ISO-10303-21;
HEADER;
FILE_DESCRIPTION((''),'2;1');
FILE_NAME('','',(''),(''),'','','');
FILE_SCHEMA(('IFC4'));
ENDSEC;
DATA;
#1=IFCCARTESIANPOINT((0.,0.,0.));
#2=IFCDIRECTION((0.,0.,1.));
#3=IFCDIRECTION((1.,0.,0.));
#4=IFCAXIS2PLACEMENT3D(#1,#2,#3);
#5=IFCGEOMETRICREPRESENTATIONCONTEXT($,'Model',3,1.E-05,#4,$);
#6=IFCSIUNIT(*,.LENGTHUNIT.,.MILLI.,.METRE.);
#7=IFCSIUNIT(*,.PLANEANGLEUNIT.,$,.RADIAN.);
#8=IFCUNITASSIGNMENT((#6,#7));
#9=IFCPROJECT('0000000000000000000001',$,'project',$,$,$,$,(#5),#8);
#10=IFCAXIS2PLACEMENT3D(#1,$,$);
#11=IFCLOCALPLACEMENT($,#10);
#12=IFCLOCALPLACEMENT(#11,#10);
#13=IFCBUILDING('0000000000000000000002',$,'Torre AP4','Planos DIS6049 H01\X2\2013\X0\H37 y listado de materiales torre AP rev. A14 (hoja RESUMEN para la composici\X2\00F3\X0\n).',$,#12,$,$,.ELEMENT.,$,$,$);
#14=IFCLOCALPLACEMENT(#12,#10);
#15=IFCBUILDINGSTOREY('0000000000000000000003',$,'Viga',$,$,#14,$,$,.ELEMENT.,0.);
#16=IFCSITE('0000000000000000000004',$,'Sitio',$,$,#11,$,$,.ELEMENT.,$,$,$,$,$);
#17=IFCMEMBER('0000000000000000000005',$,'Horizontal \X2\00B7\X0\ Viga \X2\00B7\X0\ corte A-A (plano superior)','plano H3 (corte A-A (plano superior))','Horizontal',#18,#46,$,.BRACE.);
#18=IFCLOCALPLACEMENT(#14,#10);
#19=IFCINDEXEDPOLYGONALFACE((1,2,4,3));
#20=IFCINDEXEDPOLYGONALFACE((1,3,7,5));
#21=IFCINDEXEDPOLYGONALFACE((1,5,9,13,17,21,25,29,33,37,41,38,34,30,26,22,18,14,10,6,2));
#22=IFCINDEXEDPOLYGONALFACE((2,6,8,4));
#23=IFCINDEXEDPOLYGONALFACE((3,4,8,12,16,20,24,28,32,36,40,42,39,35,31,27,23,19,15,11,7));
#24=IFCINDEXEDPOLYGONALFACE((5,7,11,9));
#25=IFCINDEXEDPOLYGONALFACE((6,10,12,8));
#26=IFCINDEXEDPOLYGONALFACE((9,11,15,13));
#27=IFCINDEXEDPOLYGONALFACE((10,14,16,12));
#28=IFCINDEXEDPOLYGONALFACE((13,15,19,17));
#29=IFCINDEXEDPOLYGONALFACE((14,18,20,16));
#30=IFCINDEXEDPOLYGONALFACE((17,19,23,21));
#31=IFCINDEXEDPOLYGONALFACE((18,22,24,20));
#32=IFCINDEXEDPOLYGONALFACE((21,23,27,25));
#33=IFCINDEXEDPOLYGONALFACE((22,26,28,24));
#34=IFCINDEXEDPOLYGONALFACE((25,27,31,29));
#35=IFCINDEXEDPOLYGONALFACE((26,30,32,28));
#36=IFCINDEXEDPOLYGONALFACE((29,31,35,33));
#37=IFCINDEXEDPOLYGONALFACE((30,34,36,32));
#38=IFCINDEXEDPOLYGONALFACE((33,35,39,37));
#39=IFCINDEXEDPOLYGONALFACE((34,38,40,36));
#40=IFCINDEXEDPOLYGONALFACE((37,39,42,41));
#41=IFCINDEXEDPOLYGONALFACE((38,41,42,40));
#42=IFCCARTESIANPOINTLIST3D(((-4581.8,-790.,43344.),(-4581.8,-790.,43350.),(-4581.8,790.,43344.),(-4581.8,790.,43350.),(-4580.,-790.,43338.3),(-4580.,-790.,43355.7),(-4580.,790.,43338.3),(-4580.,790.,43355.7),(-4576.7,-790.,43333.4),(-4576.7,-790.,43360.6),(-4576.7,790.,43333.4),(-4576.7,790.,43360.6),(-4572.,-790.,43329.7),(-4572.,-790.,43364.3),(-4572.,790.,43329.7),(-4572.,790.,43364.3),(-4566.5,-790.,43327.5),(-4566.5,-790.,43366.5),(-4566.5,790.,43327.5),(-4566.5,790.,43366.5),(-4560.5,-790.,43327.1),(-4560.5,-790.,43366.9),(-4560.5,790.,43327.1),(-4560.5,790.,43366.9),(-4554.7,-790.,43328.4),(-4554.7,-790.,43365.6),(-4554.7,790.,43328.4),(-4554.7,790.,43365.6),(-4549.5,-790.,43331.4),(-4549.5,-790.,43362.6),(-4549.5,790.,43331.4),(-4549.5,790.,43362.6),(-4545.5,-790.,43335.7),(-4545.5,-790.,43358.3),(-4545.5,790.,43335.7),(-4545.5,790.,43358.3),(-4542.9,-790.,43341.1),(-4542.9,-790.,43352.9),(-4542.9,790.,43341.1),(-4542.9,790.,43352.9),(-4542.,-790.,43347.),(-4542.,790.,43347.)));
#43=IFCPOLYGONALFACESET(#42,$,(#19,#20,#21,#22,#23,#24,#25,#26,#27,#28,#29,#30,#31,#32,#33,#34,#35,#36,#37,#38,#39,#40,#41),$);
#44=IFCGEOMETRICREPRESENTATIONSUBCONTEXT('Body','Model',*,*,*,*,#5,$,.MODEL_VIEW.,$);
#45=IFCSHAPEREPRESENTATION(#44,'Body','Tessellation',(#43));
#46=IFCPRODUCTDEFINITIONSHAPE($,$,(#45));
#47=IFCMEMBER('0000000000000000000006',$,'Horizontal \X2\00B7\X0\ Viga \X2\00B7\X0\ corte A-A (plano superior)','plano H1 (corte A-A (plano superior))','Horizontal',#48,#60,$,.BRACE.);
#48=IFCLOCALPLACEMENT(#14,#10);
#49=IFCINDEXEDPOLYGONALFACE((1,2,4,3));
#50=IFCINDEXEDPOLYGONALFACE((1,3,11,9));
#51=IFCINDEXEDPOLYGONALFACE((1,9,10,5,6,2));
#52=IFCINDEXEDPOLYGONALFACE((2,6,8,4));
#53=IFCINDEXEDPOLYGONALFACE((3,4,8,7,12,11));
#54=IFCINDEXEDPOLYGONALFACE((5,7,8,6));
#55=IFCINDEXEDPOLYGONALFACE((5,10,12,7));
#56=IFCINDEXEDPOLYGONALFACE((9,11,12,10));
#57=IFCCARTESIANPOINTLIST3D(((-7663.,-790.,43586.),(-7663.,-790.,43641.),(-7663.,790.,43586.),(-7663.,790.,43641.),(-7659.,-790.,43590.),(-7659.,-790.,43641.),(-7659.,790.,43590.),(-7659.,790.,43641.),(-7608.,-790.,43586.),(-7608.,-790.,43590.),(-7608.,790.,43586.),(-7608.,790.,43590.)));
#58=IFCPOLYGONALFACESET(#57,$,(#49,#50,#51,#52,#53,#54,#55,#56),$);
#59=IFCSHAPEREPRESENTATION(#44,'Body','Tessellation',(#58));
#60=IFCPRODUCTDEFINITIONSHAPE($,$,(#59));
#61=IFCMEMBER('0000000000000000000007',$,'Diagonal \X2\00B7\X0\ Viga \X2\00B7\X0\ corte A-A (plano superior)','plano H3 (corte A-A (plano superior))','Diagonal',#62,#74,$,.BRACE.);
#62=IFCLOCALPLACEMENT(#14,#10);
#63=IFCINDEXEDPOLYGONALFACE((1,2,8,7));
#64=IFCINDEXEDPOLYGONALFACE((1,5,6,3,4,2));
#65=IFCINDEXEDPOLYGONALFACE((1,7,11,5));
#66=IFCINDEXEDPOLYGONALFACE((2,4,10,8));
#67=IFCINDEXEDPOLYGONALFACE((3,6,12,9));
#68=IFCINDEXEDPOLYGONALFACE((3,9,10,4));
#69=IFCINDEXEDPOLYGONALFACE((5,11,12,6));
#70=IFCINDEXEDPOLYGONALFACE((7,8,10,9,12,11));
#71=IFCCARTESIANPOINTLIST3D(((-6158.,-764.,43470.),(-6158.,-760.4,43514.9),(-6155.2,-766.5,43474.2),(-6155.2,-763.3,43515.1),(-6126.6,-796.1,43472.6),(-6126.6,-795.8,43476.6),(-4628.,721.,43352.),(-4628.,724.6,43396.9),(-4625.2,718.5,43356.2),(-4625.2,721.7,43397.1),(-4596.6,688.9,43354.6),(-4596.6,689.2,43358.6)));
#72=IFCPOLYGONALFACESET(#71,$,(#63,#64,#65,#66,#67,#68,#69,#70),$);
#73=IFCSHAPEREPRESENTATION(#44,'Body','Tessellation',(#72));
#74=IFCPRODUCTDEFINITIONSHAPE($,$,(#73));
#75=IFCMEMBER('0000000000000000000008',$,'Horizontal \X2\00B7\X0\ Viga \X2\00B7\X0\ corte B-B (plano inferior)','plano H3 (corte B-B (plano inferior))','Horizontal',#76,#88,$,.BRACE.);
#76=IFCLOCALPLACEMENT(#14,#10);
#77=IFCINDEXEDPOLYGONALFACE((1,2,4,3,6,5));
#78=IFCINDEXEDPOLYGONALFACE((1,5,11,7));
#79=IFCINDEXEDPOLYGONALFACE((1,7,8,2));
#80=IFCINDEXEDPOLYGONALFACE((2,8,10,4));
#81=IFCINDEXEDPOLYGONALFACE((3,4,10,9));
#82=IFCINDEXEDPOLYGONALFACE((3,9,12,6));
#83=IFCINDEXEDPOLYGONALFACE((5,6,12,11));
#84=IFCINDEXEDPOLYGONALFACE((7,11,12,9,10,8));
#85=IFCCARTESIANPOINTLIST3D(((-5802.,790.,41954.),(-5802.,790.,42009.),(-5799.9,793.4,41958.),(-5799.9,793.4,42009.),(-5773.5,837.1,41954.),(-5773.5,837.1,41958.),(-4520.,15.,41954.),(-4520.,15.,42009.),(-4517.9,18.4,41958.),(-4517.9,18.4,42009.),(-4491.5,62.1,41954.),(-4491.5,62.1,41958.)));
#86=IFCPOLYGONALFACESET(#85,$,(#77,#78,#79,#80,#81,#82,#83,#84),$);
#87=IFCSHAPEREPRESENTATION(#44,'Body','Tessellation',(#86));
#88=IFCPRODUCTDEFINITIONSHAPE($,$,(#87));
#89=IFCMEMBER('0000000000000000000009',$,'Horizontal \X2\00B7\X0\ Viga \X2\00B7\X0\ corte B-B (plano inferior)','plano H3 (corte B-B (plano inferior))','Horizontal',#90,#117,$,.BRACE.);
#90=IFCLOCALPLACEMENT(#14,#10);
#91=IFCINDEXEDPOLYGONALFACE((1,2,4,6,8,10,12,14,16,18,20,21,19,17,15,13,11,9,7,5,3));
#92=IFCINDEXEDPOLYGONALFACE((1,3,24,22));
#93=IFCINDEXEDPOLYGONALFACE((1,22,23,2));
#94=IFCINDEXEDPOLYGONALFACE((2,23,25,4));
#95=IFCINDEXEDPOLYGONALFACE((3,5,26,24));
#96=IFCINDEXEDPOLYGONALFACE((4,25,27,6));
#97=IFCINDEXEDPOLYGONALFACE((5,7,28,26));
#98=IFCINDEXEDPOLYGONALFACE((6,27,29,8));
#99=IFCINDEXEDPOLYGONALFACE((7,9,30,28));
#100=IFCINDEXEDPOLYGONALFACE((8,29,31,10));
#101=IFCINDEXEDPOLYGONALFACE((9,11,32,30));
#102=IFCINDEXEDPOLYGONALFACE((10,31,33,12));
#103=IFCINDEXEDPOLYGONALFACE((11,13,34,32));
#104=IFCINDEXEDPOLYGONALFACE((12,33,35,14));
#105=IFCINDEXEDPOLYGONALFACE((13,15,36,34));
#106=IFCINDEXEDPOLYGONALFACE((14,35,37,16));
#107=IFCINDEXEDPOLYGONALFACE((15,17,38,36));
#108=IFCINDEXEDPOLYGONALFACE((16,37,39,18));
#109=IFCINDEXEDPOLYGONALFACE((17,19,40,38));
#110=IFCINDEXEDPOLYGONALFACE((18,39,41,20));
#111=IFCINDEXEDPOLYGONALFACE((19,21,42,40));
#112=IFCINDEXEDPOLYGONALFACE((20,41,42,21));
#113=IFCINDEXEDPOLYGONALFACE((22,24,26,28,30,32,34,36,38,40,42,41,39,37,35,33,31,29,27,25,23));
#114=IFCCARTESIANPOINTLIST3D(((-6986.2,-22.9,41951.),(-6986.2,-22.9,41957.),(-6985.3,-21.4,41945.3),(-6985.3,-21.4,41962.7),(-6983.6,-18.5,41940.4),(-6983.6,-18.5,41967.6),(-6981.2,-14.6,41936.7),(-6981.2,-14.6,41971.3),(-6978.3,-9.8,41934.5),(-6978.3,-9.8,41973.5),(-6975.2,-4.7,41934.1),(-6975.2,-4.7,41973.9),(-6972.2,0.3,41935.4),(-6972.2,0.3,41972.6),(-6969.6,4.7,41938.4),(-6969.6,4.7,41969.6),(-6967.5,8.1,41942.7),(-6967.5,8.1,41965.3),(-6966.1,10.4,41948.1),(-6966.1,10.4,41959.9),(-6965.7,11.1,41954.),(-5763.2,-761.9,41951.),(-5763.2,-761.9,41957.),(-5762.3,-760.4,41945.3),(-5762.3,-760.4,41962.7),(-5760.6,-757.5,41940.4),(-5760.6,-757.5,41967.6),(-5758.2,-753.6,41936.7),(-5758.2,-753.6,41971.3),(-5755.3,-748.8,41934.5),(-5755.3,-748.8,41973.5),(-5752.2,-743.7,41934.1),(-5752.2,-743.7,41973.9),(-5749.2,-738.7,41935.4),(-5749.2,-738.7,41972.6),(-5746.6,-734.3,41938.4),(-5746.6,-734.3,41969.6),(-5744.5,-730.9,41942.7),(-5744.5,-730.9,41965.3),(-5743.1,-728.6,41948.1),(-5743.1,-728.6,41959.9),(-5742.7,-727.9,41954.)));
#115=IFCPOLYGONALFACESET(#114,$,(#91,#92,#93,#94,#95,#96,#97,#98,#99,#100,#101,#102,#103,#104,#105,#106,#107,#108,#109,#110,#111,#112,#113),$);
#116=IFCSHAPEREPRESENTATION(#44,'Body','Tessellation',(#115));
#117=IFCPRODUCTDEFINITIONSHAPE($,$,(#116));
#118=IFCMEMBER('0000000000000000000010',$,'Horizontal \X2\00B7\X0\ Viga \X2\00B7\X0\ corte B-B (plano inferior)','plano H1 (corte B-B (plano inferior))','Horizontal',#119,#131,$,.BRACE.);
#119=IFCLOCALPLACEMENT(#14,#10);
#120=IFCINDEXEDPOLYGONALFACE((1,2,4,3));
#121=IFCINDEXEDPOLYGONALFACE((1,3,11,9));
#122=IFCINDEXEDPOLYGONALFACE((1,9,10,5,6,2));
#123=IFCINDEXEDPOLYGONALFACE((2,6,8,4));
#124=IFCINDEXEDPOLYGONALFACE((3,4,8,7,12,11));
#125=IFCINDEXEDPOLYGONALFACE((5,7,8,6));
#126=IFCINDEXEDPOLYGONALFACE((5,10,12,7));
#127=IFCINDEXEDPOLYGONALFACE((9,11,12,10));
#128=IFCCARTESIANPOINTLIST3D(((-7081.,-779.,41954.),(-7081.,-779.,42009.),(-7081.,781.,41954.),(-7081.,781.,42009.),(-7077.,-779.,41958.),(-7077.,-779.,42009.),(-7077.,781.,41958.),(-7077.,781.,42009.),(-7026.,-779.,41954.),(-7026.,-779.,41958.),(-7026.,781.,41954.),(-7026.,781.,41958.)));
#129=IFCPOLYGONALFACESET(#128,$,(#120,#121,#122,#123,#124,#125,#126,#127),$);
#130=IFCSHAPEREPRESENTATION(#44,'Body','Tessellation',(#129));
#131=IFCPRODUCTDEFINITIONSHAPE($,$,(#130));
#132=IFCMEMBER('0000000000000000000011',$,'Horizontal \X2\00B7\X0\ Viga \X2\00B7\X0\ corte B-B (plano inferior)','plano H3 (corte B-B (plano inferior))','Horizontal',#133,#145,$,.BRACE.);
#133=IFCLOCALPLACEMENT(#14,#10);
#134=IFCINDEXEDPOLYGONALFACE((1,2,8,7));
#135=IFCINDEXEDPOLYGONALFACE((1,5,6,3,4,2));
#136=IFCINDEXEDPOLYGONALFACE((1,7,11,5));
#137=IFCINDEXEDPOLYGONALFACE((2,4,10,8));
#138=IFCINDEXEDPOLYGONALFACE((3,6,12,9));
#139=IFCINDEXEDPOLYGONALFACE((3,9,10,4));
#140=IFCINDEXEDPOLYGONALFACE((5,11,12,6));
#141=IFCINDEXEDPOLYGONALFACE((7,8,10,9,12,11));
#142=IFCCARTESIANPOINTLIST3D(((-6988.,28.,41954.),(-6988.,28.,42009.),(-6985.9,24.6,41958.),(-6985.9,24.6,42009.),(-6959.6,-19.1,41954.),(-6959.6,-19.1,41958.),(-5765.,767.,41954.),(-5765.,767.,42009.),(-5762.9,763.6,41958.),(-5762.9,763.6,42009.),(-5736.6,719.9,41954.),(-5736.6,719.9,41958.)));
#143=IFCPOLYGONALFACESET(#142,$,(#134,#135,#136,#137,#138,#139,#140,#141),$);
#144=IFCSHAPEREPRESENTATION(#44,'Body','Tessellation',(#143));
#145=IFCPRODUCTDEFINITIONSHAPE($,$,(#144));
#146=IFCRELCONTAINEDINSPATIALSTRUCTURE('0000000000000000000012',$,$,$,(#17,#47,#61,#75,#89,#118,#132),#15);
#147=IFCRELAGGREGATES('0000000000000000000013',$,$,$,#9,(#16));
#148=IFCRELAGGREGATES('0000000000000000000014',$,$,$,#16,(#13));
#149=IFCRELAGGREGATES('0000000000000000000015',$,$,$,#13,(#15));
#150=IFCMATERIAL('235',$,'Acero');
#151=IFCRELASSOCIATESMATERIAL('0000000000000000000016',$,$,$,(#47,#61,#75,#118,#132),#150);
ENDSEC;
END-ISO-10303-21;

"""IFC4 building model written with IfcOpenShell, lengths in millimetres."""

from ifc_helpers import new_model, si_unit, frame, frame_2d, origin, origin_with_axes, place, context, subcontext, project, spatial, circle, l_section, extrude, material, element, save


model = new_model("IFC4")

# Units and contexts
model_context = context("Model", 3, precision=1e-05, world=origin_with_axes())
body_context = subcontext(model_context, "Body", "Model", "MODEL_VIEW")
ifc_project = project(units=[si_unit("LENGTHUNIT", "METRE", prefix="MILLI"), si_unit("PLANEANGLEUNIT", "RADIAN")], contexts=[model_context])

# Site, building, storey
site_placement = place(None, origin())
site = spatial("IfcSite", under=ifc_project, at=site_placement, Name="Sitio", CompositionType="ELEMENT")
building_placement = place(site_placement, origin())
building = spatial("IfcBuilding", under=site, at=building_placement, Name="Torre AP4", Description="Planos DIS6049 H01–H37 y listado de materiales torre AP rev. A14 (hoja RESUMEN para la composición).", CompositionType="ELEMENT")
storey_placement = place(building_placement, origin())
storey = spatial("IfcBuildingStorey", under=building, at=storey_placement, Name="Viga", CompositionType="ELEMENT", Elevation=0.0)

# Members
ifc_material_1 = material(Name="235", Category="Acero")
member_1_placement = place(storey_placement, frame((-4562.0, 790.0, 43347.0), z_axis=(0.0, -1.0, 0.0), x_axis=(1.0, 0.0, 0.0)))
element("IfcMember", 1, at=member_1_placement, inside=storey, Name="Horizontal · Viga · corte A-A (plano superior)", Description="plano H3 (corte A-A (plano superior))", ObjectType="Horizontal", PredefinedType="BRACE", context=body_context, shape_type="SweptSolid", body=[
    extrude(circle(Radius=20.0), None, (0.0, 0.0, 1.0), 1580.0),
])
member_2_placement = place(storey_placement, frame((-7663.0, 790.0, 43586.0), z_axis=(0.0, -1.0, 0.0), x_axis=(1.0, 0.0, 0.0)))
element("IfcMember", 2, at=member_2_placement, inside=storey, material=ifc_material_1, Name="Horizontal · Viga · corte A-A (plano superior)", Description="plano H1 (corte A-A (plano superior))", ObjectType="Horizontal", PredefinedType="BRACE", context=body_context, shape_type="SweptSolid", body=[
    extrude(l_section(Depth=55.0, Width=55.0, Thickness=4.0, at=frame_2d((27.5, 27.5))), None, (0.0, 0.0, 1.0), 1580.0),
])
member_3_placement = place(storey_placement, frame((-4628.0, 721.0, 43352.0), z_axis=(-0.716484, -0.695411, 0.055258), x_axis=(0.697603, -0.714197, 0.057207)))
element("IfcMember", 3, at=member_3_placement, inside=storey, material=ifc_material_1, Name="Diagonal · Viga · corte A-A (plano superior)", Description="plano H3 (corte A-A (plano superior))", ObjectType="Diagonal", PredefinedType="BRACE", context=body_context, shape_type="SweptSolid", body=[
    extrude(l_section(Depth=45.0, Width=45.0, Thickness=4.0, at=frame_2d((22.5, 22.5))), None, (0.0, 0.0, 1.0), 2135.4),
])
member_4_placement = place(storey_placement, frame((-5802.0, 790.0, 41954.0), z_axis=(0.85578, -0.51734, 0.0), x_axis=(0.51734, 0.85578, 0.0)))
element("IfcMember", 4, at=member_4_placement, inside=storey, material=ifc_material_1, Name="Horizontal · Viga · corte B-B (plano inferior)", Description="plano H3 (corte B-B (plano inferior))", ObjectType="Horizontal", PredefinedType="BRACE", context=body_context, shape_type="SweptSolid", body=[
    extrude(l_section(Depth=55.0, Width=55.0, Thickness=4.0, at=frame_2d((27.5, 27.5))), None, (0.0, 0.0, 1.0), 1498.0),
])
member_5_placement = place(storey_placement, frame((-6976.0, -6.0, 41954.0), z_axis=(0.855883, -0.517169, 0.0), x_axis=(0.517169, 0.855883, 0.0)))
element("IfcMember", 5, at=member_5_placement, inside=storey, Name="Horizontal · Viga · corte B-B (plano inferior)", Description="plano H3 (corte B-B (plano inferior))", ObjectType="Horizontal", PredefinedType="BRACE", context=body_context, shape_type="SweptSolid", body=[
    extrude(circle(Radius=20.0), None, (0.0, 0.0, 1.0), 1428.9),
])
member_6_placement = place(storey_placement, frame((-7081.0, 781.0, 41954.0), z_axis=(0.0, -1.0, 0.0), x_axis=(1.0, 0.0, 0.0)))
element("IfcMember", 6, at=member_6_placement, inside=storey, material=ifc_material_1, Name="Horizontal · Viga · corte B-B (plano inferior)", Description="plano H1 (corte B-B (plano inferior))", ObjectType="Horizontal", PredefinedType="BRACE", context=body_context, shape_type="SweptSolid", body=[
    extrude(l_section(Depth=55.0, Width=55.0, Thickness=4.0, at=frame_2d((27.5, 27.5))), None, (0.0, 0.0, 1.0), 1560.0),
])
member_7_placement = place(storey_placement, frame((-5765.0, 767.0, 41954.0), z_axis=(-0.855883, -0.517169, 0.0), x_axis=(0.517169, -0.855883, 0.0)))
element("IfcMember", 7, at=member_7_placement, inside=storey, material=ifc_material_1, Name="Horizontal · Viga · corte B-B (plano inferior)", Description="plano H3 (corte B-B (plano inferior))", ObjectType="Horizontal", PredefinedType="BRACE", context=body_context, shape_type="SweptSolid", body=[
    extrude(l_section(Depth=55.0, Width=55.0, Thickness=4.0, at=frame_2d((27.5, 27.5))), None, (0.0, 0.0, 1.0), 1428.9),
])

save(model, "model.ifc")
